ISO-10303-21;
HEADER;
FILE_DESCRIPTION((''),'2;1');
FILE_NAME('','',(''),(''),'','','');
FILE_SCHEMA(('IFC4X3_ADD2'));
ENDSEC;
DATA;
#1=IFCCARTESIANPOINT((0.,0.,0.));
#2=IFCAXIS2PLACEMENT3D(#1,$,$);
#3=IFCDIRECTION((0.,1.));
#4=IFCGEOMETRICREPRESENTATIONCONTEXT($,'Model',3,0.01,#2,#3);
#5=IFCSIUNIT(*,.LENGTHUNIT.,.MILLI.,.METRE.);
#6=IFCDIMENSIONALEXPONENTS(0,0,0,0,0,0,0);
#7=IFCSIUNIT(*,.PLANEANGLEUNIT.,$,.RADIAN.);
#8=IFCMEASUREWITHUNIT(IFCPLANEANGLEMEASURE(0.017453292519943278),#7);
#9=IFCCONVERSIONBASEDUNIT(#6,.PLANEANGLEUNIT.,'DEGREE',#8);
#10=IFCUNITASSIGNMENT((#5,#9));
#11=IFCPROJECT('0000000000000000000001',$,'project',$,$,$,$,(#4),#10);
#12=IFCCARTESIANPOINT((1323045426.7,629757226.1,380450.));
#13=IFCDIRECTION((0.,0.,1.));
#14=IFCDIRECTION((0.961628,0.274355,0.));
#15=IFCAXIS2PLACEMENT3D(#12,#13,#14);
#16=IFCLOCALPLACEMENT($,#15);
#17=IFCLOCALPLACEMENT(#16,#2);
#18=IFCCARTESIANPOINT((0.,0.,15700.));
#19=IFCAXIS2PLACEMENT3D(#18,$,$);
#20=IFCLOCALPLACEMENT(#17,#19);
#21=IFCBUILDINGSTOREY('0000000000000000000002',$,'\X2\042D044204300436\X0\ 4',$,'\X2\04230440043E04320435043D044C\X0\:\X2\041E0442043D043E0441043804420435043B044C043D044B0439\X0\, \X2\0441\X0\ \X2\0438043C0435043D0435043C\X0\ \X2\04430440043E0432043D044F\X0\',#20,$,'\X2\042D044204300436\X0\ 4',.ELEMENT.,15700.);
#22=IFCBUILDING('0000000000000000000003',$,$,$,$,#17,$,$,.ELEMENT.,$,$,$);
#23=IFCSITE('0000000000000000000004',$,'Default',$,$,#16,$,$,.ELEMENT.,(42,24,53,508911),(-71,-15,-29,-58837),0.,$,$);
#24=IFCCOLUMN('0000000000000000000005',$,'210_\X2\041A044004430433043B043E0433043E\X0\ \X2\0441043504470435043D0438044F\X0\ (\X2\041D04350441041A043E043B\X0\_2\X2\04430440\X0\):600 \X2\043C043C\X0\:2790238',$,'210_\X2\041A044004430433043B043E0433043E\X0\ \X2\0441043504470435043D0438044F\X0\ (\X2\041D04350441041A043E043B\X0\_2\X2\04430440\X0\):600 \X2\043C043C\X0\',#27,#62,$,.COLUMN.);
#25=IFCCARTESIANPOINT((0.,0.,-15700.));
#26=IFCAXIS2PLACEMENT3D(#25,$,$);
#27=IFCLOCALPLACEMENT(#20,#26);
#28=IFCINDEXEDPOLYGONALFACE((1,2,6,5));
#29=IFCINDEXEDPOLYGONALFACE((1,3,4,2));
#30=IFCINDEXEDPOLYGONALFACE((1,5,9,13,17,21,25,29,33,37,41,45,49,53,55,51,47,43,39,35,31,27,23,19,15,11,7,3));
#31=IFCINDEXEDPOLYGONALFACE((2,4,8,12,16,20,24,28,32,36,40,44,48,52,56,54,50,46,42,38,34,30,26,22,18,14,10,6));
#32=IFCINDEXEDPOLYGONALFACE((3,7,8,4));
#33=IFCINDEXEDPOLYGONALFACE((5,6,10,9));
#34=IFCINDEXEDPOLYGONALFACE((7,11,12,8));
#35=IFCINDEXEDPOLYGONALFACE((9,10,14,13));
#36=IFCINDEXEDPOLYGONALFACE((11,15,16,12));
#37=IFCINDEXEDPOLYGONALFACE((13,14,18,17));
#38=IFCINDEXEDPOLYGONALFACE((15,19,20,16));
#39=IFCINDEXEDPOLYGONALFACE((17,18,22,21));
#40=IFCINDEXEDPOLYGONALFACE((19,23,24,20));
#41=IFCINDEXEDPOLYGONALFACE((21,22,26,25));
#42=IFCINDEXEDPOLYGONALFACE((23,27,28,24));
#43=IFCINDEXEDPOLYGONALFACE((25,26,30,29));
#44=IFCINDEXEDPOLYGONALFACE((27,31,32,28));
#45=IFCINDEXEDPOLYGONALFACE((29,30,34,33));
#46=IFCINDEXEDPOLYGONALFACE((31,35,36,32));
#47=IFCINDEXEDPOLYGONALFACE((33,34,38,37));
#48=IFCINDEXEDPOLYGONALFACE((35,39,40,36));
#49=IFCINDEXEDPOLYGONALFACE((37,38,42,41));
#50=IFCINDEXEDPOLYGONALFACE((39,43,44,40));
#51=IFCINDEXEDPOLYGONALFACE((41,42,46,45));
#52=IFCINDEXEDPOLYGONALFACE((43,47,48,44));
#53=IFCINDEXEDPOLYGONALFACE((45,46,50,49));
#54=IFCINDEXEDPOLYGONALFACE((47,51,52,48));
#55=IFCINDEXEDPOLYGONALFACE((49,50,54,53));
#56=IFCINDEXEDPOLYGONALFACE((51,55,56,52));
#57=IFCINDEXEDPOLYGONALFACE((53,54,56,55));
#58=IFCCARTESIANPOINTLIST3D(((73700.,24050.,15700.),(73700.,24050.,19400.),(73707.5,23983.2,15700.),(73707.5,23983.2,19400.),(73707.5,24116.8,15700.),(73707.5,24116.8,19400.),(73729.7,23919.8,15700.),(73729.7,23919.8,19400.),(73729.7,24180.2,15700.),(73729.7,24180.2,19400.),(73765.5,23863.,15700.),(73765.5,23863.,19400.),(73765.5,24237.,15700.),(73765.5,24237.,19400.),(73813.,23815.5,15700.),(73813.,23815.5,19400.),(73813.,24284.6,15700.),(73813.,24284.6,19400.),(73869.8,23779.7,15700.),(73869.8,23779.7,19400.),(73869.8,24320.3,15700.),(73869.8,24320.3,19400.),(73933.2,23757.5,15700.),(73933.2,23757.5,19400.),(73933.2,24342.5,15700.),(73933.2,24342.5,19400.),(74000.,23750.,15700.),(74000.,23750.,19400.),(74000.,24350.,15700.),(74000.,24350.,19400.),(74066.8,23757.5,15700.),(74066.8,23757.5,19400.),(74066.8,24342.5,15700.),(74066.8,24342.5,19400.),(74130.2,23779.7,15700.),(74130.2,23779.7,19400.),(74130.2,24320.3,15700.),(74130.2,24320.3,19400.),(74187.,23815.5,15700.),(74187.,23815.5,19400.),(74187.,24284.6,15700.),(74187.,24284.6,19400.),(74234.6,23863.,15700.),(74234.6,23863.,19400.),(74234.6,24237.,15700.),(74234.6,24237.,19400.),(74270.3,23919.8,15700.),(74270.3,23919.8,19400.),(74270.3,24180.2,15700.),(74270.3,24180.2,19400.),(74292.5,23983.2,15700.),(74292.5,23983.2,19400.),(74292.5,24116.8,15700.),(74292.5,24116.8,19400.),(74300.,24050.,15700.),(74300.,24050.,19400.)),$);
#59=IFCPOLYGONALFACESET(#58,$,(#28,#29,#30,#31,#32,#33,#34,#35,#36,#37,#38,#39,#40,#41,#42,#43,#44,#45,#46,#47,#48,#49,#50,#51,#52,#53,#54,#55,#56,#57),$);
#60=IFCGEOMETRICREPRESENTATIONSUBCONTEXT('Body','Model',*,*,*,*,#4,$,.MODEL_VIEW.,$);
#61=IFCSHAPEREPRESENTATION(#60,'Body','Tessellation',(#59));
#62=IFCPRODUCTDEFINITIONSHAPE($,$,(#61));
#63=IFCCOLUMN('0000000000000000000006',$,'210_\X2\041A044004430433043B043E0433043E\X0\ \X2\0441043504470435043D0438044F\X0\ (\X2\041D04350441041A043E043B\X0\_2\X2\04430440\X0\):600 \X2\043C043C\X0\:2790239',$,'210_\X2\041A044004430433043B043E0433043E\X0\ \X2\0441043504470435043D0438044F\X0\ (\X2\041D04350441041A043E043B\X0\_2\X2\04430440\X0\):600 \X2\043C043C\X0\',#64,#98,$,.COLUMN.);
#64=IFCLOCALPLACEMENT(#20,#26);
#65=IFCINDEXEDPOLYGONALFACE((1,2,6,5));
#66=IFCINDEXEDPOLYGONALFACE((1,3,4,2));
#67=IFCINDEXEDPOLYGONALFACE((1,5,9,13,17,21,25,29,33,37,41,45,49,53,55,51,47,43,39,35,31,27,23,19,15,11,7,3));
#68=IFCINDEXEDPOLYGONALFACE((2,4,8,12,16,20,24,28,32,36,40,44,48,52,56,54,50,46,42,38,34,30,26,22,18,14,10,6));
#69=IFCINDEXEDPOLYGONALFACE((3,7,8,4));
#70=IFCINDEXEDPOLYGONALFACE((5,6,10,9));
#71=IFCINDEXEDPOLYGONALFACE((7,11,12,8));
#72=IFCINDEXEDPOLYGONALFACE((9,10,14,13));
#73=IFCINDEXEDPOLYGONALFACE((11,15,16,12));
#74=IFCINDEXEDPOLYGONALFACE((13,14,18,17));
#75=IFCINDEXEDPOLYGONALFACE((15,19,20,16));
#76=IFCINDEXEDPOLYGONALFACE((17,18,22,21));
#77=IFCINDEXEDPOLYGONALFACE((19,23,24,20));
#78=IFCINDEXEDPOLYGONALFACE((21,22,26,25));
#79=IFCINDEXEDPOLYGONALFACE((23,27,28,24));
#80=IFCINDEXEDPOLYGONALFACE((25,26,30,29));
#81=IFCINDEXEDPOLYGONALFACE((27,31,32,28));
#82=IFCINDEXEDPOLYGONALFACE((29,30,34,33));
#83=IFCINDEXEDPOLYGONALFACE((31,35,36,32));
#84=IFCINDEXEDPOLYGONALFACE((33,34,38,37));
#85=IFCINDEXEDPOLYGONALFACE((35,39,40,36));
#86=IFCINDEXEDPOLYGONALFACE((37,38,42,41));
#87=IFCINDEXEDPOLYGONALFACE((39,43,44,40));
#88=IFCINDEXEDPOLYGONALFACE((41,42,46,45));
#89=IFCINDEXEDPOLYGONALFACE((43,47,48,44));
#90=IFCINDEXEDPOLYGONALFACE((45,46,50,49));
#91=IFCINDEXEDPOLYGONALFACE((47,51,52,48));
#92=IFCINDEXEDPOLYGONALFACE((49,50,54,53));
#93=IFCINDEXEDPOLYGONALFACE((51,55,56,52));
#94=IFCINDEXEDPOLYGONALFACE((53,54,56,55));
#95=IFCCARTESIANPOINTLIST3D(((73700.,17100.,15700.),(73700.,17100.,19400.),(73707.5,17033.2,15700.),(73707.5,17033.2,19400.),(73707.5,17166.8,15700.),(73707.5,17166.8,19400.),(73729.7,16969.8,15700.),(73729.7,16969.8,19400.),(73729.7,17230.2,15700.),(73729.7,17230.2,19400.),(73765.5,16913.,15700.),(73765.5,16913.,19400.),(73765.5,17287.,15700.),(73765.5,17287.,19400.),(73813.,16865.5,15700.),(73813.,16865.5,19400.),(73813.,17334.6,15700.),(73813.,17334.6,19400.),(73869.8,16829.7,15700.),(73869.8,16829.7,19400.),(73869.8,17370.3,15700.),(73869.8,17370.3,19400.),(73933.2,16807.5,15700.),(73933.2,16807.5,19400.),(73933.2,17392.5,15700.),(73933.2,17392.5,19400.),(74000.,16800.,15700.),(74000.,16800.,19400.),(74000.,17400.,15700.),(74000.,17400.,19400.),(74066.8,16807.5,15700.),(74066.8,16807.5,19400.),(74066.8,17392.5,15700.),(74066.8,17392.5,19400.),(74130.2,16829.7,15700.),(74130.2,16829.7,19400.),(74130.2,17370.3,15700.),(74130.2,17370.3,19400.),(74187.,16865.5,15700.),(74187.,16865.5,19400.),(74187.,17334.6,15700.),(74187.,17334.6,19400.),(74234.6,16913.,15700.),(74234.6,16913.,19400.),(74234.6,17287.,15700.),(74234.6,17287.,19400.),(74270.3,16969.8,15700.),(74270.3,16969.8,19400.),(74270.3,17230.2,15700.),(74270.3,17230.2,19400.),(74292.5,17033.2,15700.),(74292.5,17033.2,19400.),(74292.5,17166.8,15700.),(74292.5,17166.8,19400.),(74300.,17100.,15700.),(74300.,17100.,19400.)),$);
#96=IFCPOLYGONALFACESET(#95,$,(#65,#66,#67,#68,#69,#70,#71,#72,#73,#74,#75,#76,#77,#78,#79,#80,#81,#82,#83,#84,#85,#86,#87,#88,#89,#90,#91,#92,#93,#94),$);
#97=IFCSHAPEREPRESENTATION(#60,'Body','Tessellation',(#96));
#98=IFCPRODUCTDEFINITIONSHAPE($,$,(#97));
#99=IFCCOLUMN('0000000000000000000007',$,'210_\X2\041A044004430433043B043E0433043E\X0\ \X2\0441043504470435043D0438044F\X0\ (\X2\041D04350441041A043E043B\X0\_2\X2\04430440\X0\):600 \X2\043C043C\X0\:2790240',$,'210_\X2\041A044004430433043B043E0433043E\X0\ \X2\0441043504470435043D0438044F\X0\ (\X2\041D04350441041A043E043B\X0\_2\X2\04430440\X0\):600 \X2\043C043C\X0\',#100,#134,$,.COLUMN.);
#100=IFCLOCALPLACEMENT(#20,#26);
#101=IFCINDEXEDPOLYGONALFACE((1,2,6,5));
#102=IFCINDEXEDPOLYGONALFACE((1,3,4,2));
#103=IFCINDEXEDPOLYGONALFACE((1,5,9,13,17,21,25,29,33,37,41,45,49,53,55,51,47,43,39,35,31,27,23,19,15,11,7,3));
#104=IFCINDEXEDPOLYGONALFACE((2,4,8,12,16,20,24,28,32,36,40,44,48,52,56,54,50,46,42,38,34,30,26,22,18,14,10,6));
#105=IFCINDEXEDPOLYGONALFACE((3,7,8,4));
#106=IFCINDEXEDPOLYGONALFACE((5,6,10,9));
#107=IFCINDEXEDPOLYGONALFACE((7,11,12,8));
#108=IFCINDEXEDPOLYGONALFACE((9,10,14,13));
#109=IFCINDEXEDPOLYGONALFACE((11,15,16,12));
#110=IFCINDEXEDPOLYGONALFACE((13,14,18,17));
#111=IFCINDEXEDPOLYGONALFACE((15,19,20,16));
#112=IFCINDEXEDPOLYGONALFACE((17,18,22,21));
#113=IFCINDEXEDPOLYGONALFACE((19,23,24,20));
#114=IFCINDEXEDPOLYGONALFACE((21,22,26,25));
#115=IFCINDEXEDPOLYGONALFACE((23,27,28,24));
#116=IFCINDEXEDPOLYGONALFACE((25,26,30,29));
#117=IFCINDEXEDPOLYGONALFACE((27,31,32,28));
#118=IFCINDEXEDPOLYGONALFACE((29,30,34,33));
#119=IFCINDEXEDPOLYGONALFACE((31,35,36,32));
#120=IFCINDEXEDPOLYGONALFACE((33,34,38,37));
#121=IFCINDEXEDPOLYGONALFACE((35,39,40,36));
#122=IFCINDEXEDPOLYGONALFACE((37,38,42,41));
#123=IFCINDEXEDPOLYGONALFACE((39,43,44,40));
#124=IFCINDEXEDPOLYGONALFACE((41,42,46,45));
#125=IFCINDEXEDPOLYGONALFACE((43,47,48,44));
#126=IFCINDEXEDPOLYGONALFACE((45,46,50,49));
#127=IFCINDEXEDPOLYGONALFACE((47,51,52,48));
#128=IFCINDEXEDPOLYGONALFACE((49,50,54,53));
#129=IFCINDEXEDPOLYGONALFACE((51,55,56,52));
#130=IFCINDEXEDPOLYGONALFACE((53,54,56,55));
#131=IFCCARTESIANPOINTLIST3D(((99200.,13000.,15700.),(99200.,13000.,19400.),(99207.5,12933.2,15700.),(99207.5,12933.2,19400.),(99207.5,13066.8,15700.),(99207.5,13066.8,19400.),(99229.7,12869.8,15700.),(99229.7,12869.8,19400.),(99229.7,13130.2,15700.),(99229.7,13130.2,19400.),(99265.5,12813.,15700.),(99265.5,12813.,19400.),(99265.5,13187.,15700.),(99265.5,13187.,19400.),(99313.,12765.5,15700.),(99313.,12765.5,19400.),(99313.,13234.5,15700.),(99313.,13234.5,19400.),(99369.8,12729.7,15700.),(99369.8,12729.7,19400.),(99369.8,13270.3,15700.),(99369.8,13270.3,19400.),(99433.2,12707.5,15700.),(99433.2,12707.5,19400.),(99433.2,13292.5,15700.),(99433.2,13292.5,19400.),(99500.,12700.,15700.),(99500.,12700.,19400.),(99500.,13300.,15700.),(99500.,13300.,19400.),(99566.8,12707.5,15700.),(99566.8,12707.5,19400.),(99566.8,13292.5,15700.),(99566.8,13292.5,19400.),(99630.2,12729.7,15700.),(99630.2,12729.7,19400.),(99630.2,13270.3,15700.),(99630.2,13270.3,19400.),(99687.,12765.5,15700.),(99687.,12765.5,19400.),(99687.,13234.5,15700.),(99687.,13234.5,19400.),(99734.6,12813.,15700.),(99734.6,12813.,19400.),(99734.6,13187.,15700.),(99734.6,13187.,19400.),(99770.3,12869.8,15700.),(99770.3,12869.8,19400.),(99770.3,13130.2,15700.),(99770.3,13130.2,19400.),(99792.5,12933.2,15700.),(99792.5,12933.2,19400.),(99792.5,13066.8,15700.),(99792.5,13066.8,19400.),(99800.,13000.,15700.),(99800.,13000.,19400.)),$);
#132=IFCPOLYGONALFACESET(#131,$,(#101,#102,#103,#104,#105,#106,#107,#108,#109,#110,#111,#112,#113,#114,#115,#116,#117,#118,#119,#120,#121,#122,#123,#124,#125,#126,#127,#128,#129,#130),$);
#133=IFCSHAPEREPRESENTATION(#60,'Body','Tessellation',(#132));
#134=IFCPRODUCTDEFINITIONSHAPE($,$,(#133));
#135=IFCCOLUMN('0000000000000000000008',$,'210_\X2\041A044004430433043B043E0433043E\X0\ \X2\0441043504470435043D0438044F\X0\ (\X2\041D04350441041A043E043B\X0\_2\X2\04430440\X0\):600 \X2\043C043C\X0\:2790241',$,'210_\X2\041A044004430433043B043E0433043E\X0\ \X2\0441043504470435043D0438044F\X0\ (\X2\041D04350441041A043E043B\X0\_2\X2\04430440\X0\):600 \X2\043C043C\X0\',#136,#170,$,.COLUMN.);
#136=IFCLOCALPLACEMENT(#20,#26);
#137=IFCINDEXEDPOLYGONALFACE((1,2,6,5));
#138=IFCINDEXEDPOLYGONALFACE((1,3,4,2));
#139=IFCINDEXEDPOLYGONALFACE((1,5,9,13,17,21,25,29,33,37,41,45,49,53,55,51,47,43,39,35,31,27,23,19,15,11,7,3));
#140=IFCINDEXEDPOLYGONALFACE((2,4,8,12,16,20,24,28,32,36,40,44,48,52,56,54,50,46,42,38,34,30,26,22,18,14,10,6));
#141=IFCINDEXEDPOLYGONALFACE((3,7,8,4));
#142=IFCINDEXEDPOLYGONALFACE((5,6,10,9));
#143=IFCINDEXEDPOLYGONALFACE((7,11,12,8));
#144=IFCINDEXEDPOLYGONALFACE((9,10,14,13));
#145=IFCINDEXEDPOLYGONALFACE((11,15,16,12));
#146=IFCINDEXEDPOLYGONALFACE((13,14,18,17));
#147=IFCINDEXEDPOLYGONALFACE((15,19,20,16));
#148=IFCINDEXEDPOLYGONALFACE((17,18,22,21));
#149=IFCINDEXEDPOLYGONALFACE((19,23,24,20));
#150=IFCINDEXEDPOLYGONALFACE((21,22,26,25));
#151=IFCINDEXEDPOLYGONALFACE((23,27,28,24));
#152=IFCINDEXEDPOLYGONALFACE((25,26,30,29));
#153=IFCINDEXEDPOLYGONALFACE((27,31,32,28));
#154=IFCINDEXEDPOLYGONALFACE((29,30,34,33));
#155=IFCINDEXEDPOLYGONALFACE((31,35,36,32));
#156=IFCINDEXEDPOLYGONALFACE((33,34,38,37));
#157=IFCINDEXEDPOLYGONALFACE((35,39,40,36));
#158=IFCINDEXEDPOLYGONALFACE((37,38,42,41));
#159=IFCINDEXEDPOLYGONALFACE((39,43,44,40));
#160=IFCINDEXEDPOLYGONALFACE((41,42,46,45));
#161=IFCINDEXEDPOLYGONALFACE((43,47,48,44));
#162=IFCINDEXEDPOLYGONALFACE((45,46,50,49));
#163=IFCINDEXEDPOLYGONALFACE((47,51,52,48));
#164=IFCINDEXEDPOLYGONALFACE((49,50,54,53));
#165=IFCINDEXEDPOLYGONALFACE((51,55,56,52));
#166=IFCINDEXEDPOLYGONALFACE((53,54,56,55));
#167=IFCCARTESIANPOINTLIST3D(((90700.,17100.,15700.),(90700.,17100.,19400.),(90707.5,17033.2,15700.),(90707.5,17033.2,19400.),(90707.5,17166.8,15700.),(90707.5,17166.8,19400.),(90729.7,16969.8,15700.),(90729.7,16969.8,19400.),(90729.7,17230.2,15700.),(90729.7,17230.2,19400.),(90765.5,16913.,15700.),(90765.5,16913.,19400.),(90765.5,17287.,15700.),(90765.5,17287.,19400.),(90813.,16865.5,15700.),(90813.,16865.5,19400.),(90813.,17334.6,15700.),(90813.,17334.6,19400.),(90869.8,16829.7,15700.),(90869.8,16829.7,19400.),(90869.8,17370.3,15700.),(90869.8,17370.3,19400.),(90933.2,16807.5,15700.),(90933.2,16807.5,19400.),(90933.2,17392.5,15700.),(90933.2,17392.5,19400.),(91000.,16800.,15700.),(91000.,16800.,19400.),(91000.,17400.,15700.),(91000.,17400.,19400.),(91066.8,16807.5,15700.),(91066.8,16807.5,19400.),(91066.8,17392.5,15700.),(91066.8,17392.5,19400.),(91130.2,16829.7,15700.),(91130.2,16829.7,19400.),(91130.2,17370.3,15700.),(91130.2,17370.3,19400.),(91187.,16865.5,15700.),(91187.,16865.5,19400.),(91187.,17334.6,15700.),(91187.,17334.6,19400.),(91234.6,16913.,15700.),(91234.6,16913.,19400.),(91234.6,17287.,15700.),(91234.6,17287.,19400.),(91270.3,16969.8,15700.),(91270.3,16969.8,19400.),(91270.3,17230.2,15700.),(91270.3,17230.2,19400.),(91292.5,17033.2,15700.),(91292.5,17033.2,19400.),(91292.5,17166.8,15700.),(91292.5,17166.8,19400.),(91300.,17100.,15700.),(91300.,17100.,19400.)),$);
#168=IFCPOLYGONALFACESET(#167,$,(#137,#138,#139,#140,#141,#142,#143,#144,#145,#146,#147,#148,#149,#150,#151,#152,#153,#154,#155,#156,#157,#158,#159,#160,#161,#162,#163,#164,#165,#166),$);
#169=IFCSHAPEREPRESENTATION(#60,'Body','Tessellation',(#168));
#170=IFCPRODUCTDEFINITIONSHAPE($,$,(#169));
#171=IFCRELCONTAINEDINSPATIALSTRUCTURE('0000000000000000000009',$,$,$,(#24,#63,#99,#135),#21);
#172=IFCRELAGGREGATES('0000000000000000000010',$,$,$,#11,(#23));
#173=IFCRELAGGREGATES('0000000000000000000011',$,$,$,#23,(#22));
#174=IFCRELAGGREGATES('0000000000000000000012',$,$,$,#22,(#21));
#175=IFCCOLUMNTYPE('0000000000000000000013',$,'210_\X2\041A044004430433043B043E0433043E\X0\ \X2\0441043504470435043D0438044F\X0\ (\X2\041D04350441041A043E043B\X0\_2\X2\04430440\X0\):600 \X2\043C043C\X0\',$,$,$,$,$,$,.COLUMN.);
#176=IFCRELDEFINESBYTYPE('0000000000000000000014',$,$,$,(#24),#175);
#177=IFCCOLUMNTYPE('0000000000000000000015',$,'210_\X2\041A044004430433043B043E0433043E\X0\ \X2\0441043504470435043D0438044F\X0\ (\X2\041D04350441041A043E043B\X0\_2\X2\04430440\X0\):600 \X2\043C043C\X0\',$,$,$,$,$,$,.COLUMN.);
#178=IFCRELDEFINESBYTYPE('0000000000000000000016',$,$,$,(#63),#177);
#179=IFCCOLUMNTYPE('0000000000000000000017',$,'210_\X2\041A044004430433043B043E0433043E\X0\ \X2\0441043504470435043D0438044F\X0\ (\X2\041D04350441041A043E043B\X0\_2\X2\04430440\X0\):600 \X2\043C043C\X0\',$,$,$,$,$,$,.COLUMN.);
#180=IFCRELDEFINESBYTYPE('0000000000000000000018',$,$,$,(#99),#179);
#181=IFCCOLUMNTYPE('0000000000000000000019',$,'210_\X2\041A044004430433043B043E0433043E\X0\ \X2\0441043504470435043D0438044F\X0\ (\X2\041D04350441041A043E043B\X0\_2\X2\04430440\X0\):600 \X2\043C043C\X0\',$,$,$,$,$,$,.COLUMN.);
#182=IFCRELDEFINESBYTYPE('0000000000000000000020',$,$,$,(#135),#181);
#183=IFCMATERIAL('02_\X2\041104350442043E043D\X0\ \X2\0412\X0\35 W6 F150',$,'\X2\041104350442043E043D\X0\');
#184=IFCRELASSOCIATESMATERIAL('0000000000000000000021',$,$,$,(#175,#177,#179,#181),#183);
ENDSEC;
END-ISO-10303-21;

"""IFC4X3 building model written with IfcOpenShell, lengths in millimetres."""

from ifc_helpers import new_model, entity, si_unit, converted_unit, direction, frame, origin, origin_2d_with_axis, place, context, subcontext, project, spatial, circle, extrude, source, transform, mapped, material, material_profile, profile_set, type_object, type_shapes, element, save


model = new_model("IFC4X3")

# Units and contexts
model_context = context("Model", 3, precision=0.01, world=origin(), true_north=direction((0.0, 1.0)))
body_context = subcontext(model_context, "Body", "Model", "MODEL_VIEW")
ifc_project = project(units=[si_unit("LENGTHUNIT", "METRE", prefix="MILLI"), converted_unit("PLANEANGLEUNIT", "DEGREE", entity("IfcPlaneAngleMeasure", 0.017453292519943278), si_unit("PLANEANGLEUNIT", "RADIAN"), dimensions=[0, 0, 0, 0, 0, 0, 0])], contexts=[model_context])

# Site, building, storey
site_placement = place(None, frame((1323045426.7, 629757226.1, 380450.0), z_axis=(0.0, 0.0, 1.0), x_axis=(0.961628, 0.274355, 0.0)))
site = spatial("IfcSite", under=ifc_project, at=site_placement, Name="Default", CompositionType="ELEMENT", RefLatitude=(42, 24, 53, 508911), RefLongitude=(-71, -15, -29, -58837), RefElevation=0.0)
building_placement = place(site_placement, origin())
building = spatial("IfcBuilding", under=site, at=building_placement, CompositionType="ELEMENT")
storey_placement = place(building_placement, frame((0.0, 0.0, 15700.0)))
storey = spatial("IfcBuildingStorey", under=building, at=storey_placement, Name="Этаж 4", ObjectType="Уровень:Относительный, с именем уровня", LongName="Этаж 4", CompositionType="ELEMENT", Elevation=15700.0)

# Columns
ifc_material = material(Name="02_Бетон В35 W6 F150", Category="Бетон")
ifc_material_profile = material_profile(ifc_material, circle(Radius=300.0, at=origin_2d_with_axis()), Name="600 мм")
ifc_profile_set = profile_set([ifc_material_profile], Name="600 мм")
column_type_1 = type_object("IfcColumnType", Name="210_Круглого сечения (НесКол_2ур):600 мм", PredefinedType="COLUMN", material=ifc_profile_set)
shared_shape_1 = source(origin(), body_context, "Body", "SweptSolid", [
    extrude(circle(Radius=300.0, at=origin_2d_with_axis()), frame((74000.0, 24050.0, 15700.0)), (0.0, 0.0, 1.0), 3700.0),
])
type_shapes(column_type_1, [shared_shape_1])
column_1_placement = place(storey_placement, frame((0.0, 0.0, -15700.0)))
element("IfcColumn", 1, at=column_1_placement, inside=storey, type_object=column_type_1, Name="210_Круглого сечения (НесКол_2ур):600 мм:2790238", ObjectType="210_Круглого сечения (НесКол_2ур):600 мм", PredefinedType="COLUMN", context=body_context, shape_type="MappedRepresentation", body=[
    mapped(shared_shape_1, transform((0.0, 0.0, 0.0), scale=1.0)),
])
column_type_2 = type_object("IfcColumnType", Name="210_Круглого сечения (НесКол_2ур):600 мм", PredefinedType="COLUMN", material=ifc_profile_set)
shared_shape_2 = source(origin(), body_context, "Body", "SweptSolid", [
    extrude(circle(Radius=300.0, at=origin_2d_with_axis()), frame((74000.0, 17100.0, 15700.0)), (0.0, 0.0, 1.0), 3700.0),
])
type_shapes(column_type_2, [shared_shape_2])
column_2_placement = place(storey_placement, frame((0.0, 0.0, -15700.0)))
element("IfcColumn", 2, at=column_2_placement, inside=storey, type_object=column_type_2, Name="210_Круглого сечения (НесКол_2ур):600 мм:2790239", ObjectType="210_Круглого сечения (НесКол_2ур):600 мм", PredefinedType="COLUMN", context=body_context, shape_type="MappedRepresentation", body=[
    mapped(shared_shape_2, transform((0.0, 0.0, 0.0), scale=1.0)),
])
column_type_3 = type_object("IfcColumnType", Name="210_Круглого сечения (НесКол_2ур):600 мм", PredefinedType="COLUMN", material=ifc_profile_set)
shared_shape_3 = source(origin(), body_context, "Body", "SweptSolid", [
    extrude(circle(Radius=300.0, at=origin_2d_with_axis()), frame((99500.0, 13000.0, 15700.0)), (0.0, 0.0, 1.0), 3700.0),
])
type_shapes(column_type_3, [shared_shape_3])
column_3_placement = place(storey_placement, frame((0.0, 0.0, -15700.0)))
element("IfcColumn", 3, at=column_3_placement, inside=storey, type_object=column_type_3, Name="210_Круглого сечения (НесКол_2ур):600 мм:2790240", ObjectType="210_Круглого сечения (НесКол_2ур):600 мм", PredefinedType="COLUMN", context=body_context, shape_type="MappedRepresentation", body=[
    mapped(shared_shape_3, transform((0.0, 0.0, 0.0), scale=1.0)),
])
column_type_4 = type_object("IfcColumnType", Name="210_Круглого сечения (НесКол_2ур):600 мм", PredefinedType="COLUMN", material=ifc_profile_set)
shared_shape_4 = source(origin(), body_context, "Body", "SweptSolid", [
    extrude(circle(Radius=300.0, at=origin_2d_with_axis()), frame((91000.0, 17100.0, 15700.0)), (0.0, 0.0, 1.0), 3700.0),
])
type_shapes(column_type_4, [shared_shape_4])
column_4_placement = place(storey_placement, frame((0.0, 0.0, -15700.0)))
element("IfcColumn", 4, at=column_4_placement, inside=storey, type_object=column_type_4, Name="210_Круглого сечения (НесКол_2ур):600 мм:2790241", ObjectType="210_Круглого сечения (НесКол_2ур):600 мм", PredefinedType="COLUMN", context=body_context, shape_type="MappedRepresentation", body=[
    mapped(shared_shape_4, transform((0.0, 0.0, 0.0), scale=1.0)),
])

save(model, "model.ifc")
